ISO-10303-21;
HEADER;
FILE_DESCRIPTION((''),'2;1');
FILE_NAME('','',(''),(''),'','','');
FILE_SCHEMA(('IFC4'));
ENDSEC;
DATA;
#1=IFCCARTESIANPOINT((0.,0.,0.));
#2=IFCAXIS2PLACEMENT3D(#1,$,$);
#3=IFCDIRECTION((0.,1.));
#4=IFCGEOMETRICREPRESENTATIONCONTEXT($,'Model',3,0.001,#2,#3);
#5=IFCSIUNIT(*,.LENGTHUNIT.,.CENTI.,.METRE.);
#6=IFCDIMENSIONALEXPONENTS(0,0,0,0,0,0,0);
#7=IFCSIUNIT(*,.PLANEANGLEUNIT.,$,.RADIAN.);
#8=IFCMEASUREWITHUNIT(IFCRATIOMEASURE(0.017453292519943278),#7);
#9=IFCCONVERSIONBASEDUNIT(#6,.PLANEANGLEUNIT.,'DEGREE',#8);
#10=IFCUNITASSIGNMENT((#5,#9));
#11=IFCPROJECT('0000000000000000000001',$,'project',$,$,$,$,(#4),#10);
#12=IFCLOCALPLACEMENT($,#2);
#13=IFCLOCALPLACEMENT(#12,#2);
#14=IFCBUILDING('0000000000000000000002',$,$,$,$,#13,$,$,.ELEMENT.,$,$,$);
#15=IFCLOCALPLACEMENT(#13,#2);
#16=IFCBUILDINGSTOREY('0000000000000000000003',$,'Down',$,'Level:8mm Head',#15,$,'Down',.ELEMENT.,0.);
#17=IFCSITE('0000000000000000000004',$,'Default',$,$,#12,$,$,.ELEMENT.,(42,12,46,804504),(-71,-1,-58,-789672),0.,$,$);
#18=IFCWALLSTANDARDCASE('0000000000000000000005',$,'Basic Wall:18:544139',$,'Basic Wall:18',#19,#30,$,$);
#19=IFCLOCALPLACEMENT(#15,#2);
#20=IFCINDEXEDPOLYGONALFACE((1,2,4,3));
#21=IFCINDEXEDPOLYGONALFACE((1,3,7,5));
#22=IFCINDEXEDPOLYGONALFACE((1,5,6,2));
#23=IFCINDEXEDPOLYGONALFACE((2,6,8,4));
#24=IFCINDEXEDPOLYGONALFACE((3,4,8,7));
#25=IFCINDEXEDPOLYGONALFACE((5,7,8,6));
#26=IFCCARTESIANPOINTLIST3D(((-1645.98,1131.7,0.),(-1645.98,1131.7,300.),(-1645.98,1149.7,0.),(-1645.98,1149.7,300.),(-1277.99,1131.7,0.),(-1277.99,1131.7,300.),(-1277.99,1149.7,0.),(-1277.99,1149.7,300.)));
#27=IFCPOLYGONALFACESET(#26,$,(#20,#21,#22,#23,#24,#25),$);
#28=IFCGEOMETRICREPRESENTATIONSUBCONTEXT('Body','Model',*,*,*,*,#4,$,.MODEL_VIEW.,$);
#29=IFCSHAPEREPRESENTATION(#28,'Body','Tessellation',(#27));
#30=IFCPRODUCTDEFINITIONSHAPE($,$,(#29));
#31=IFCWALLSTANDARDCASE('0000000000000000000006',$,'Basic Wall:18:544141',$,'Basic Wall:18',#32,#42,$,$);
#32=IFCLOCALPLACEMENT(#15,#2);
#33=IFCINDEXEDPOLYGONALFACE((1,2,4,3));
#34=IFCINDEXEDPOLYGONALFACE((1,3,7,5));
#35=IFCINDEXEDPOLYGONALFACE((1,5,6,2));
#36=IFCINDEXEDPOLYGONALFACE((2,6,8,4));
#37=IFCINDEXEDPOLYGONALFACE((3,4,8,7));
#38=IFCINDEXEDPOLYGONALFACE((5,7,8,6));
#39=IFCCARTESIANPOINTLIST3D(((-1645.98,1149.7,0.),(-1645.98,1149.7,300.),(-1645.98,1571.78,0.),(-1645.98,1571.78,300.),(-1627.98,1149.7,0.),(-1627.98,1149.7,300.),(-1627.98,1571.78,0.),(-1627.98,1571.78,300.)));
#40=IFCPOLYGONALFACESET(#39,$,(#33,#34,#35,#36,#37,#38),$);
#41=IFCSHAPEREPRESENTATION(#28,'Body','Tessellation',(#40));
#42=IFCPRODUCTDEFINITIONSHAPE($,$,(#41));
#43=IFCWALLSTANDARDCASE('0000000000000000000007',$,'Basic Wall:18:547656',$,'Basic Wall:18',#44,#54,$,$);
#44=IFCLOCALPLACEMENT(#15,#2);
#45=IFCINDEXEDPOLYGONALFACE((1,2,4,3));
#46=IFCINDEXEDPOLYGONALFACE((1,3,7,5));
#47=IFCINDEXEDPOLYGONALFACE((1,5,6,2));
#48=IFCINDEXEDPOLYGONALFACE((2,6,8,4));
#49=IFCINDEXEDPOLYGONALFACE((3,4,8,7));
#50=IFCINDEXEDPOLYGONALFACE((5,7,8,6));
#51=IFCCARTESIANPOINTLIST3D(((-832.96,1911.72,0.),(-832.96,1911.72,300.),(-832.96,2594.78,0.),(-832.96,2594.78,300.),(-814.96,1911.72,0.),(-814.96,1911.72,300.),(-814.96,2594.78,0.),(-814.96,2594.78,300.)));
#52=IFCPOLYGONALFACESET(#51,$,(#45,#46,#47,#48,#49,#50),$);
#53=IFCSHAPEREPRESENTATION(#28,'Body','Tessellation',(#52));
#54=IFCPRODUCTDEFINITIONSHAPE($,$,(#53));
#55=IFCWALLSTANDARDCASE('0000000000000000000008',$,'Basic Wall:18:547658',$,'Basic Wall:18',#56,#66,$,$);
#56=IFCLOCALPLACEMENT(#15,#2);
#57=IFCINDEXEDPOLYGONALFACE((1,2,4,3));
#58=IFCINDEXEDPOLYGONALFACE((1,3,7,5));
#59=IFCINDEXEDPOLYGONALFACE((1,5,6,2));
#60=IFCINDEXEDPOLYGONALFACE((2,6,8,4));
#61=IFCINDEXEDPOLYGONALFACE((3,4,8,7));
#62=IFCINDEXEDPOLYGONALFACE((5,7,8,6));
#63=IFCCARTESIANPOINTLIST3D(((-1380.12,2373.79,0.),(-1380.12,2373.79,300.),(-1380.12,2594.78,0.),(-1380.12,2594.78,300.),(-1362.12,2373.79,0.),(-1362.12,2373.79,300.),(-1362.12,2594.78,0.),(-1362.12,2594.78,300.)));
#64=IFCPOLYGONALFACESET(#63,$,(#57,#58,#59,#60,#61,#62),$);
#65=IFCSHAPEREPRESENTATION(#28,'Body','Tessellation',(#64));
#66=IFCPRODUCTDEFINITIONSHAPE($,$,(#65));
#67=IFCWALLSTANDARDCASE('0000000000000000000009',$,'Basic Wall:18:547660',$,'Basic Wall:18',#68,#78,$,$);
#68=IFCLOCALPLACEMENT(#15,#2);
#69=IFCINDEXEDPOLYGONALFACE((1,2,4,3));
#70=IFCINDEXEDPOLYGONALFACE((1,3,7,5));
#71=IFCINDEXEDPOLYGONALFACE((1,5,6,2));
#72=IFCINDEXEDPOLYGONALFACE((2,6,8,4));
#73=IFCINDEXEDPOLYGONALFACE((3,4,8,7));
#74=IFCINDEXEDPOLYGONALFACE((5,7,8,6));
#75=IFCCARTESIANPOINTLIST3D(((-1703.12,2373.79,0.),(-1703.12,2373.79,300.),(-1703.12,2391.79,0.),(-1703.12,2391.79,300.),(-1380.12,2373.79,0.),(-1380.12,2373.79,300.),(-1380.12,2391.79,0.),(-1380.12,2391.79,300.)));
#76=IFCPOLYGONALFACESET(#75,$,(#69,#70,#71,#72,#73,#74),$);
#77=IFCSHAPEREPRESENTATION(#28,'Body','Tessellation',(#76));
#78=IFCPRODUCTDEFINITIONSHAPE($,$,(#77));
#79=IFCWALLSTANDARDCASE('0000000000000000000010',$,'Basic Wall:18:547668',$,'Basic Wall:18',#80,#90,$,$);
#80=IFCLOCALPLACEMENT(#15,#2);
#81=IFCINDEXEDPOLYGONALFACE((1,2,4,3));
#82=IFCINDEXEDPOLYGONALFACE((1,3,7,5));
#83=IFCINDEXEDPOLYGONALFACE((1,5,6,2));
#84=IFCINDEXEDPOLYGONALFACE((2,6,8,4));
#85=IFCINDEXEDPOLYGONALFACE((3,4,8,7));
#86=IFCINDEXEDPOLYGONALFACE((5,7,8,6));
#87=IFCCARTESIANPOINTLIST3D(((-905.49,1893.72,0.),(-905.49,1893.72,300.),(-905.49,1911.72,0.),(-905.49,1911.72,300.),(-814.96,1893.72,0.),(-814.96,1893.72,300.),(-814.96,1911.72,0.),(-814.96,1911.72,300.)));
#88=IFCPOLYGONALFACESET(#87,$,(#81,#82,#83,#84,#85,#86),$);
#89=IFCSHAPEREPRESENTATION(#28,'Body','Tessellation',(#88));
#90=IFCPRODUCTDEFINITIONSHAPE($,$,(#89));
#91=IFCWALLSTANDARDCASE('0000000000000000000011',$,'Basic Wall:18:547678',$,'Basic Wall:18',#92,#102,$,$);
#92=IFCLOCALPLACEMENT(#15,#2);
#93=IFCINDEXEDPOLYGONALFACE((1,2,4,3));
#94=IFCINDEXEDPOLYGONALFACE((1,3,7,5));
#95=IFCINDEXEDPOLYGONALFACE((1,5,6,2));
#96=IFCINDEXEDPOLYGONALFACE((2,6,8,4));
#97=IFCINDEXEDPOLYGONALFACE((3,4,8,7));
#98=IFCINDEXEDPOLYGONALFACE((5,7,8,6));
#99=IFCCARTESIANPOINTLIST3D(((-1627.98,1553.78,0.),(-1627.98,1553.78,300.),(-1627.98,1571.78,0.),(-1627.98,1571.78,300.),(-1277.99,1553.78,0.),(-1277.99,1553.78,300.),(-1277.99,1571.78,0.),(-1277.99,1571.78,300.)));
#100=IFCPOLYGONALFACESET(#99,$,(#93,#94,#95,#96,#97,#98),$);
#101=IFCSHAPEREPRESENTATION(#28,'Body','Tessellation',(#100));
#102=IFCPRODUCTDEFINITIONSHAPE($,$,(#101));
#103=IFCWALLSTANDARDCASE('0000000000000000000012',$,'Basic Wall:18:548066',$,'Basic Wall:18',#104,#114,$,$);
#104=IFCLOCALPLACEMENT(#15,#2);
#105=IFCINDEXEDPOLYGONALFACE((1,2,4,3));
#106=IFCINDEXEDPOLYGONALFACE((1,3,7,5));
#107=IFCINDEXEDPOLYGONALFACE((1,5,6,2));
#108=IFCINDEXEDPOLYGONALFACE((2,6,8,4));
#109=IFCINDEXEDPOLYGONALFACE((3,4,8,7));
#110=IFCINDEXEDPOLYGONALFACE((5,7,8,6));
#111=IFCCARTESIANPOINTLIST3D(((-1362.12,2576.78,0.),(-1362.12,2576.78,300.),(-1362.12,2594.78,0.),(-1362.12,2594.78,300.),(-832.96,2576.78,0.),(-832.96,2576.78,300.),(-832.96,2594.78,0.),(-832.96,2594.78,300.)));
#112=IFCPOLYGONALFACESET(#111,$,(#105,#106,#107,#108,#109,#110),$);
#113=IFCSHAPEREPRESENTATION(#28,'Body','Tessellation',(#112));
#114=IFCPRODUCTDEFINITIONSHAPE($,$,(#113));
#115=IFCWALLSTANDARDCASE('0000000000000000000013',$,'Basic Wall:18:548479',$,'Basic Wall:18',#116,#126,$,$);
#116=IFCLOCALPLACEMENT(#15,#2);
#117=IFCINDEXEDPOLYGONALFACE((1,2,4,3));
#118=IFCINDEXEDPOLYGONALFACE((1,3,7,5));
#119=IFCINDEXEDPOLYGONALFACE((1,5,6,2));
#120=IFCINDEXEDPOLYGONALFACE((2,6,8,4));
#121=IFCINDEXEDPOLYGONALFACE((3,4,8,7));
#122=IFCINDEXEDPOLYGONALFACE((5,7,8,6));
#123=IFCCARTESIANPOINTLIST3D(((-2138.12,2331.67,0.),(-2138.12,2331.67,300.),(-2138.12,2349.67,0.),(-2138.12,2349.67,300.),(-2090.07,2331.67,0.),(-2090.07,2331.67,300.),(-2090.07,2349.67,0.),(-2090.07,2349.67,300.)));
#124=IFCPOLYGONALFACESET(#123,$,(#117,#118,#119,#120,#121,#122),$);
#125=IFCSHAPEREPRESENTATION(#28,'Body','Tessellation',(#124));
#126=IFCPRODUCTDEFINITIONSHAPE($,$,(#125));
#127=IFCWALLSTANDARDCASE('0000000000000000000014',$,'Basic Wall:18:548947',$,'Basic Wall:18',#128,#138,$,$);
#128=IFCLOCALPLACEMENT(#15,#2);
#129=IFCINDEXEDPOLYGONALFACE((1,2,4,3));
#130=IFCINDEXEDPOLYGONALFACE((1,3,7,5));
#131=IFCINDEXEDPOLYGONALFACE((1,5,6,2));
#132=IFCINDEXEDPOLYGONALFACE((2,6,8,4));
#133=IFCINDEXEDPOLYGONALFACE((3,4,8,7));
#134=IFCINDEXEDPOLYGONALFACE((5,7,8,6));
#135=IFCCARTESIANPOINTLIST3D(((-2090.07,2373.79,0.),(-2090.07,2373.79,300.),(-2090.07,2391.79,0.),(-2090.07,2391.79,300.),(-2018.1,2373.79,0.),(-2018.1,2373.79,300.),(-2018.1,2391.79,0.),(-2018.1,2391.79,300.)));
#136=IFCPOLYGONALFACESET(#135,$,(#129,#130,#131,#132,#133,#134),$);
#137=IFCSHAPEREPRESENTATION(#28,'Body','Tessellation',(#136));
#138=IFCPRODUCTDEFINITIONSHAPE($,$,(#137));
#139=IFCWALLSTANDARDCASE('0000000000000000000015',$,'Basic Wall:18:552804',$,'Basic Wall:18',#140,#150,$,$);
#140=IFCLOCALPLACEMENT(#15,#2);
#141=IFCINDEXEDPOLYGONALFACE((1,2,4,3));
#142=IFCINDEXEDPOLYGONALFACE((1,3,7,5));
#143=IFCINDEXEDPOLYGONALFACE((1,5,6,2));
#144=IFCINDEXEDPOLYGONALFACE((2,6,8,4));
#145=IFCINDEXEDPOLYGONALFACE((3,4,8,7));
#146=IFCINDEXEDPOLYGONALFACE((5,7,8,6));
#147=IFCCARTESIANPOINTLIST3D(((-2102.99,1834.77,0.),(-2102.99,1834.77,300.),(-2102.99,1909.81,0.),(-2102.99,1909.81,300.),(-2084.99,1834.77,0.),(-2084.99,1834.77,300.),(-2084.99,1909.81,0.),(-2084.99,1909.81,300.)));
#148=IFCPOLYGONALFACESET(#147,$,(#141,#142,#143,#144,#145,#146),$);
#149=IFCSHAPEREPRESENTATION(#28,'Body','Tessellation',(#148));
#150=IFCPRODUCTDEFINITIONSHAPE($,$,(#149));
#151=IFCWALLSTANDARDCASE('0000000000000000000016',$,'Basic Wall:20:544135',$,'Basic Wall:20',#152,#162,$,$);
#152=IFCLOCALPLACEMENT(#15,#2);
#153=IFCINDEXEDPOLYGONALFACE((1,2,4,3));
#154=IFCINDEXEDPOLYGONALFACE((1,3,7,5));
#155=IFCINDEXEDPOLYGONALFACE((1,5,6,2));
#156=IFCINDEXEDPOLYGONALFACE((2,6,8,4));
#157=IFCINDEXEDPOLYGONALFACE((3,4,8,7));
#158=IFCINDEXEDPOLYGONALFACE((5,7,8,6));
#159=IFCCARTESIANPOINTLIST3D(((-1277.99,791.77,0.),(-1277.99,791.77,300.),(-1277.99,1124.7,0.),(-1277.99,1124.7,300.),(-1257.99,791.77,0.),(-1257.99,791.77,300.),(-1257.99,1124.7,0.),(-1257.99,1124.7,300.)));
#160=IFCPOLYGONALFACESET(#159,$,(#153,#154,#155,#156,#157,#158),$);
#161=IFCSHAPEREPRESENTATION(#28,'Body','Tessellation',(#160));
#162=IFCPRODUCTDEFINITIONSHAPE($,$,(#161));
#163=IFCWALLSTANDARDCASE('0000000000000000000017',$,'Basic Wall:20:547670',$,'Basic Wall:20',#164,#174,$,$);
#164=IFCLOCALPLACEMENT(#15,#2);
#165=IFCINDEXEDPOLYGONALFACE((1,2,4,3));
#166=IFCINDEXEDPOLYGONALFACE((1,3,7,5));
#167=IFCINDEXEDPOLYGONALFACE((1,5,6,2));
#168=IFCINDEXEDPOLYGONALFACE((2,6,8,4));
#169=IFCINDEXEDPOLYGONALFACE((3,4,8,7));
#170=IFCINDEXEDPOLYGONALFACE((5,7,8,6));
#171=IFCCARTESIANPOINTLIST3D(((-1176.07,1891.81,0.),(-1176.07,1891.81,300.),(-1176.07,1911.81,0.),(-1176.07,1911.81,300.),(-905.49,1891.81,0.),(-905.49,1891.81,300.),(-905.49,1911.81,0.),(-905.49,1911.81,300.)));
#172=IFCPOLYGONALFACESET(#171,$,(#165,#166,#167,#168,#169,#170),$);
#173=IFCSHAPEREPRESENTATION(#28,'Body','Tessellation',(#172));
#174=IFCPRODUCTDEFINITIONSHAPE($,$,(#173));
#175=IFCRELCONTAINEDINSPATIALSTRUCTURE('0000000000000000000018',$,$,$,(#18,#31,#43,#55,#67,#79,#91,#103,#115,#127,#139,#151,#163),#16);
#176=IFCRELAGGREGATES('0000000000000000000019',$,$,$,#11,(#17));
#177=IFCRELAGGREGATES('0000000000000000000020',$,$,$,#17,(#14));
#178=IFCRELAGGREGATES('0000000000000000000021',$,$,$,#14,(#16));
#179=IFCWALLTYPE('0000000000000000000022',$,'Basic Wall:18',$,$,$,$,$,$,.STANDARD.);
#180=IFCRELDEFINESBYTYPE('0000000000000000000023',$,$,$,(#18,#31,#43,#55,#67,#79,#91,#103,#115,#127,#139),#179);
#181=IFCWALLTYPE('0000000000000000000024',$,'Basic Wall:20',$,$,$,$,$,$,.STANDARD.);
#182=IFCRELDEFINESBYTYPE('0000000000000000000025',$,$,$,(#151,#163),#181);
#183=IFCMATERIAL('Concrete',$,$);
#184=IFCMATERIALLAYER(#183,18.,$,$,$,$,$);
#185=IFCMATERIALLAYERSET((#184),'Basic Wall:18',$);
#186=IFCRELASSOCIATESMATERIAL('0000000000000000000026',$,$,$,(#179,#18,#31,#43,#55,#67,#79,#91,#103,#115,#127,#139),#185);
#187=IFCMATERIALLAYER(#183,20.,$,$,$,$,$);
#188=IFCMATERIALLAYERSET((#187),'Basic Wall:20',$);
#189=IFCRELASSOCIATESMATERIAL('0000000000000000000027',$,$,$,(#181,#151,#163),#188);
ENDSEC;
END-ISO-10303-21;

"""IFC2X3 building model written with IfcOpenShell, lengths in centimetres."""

from ifc_helpers import new_model, entity, si_unit, converted_unit, direction, frame, frame_2d, origin, place, context, subcontext, project, spatial, rectangle, extrude, material, layer, layer_set, layer_usage, type_object, element, save


model = new_model("IFC2X3")

# Units and contexts
model_context = context("Model", 3, precision=0.001, world=origin(), true_north=direction((0.0, 1.0)))
body_context = subcontext(model_context, "Body", "Model", "MODEL_VIEW")
ifc_project = project(units=[si_unit("LENGTHUNIT", "METRE", prefix="CENTI"), converted_unit("PLANEANGLEUNIT", "DEGREE", entity("IfcRatioMeasure", 0.017453292519943278), si_unit("PLANEANGLEUNIT", "RADIAN"), dimensions=[0, 0, 0, 0, 0, 0, 0])], contexts=[model_context])

# Site, building, storey
site_placement = place(None, origin())
site = spatial("IfcSite", under=ifc_project, at=site_placement, Name="Default", CompositionType="ELEMENT", RefLatitude=(42, 12, 46, 804504), RefLongitude=(-71, -1, -58, -789672), RefElevation=0.0)
building_placement = place(site_placement, origin())
building = spatial("IfcBuilding", under=site, at=building_placement, CompositionType="ELEMENT")
storey_placement = place(building_placement, origin())
storey = spatial("IfcBuildingStorey", under=building, at=storey_placement, Name="Down", ObjectType="Level:8mm Head", LongName="Down", CompositionType="ELEMENT", Elevation=0.0)

# Walls
ifc_material = material(Name="Concrete")
ifc_layer_1 = layer(ifc_material, 18.0)
ifc_layer_set_1 = layer_set([ifc_layer_1], Name="Basic Wall:18")
ifc_layer_usage_1 = layer_usage(ifc_layer_set_1, "AXIS2", "POSITIVE", -9.0)
wall_type_1 = type_object("IfcWallType", Name="Basic Wall:18", PredefinedType="STANDARD", material=ifc_layer_set_1)
wall_1_placement = place(storey_placement, frame((-1277.99, 1140.7, 0.0), z_axis=(0.0, 0.0, 1.0), x_axis=(-1.0, 0.0, 0.0)))
element("IfcWallStandardCase", 1, at=wall_1_placement, inside=storey, type_object=wall_type_1, material=ifc_layer_usage_1, Name="Basic Wall:18:544139", ObjectType="Basic Wall:18", context=body_context, shape_type="SweptSolid", body=[
    extrude(rectangle(XDim=367.99, YDim=18.0, at=frame_2d((184.0, 0.0), x_axis=(-1.0, 0.0))), origin(), (0.0, 0.0, 1.0), 300.0),
])
ifc_layer_usage_2 = layer_usage(ifc_layer_set_1, "AXIS2", "NEGATIVE", 9.0)
wall_2_placement = place(storey_placement, frame((-1636.98, 1149.7, 0.0), z_axis=(0.0, 0.0, 1.0), x_axis=(0.0, 1.0, 0.0)))
element("IfcWallStandardCase", 2, at=wall_2_placement, inside=storey, type_object=wall_type_1, material=ifc_layer_usage_2, Name="Basic Wall:18:544141", ObjectType="Basic Wall:18", context=body_context, shape_type="SweptSolid", body=[
    extrude(rectangle(XDim=422.07, YDim=18.0, at=frame_2d((211.04, 0.0), x_axis=(-1.0, 0.0))), origin(), (0.0, 0.0, 1.0), 300.0),
])
ifc_layer_usage_3 = layer_usage(ifc_layer_set_1, "AXIS2", "POSITIVE", -9.0)
wall_3_placement = place(storey_placement, frame((-823.96, 1911.72, 0.0), z_axis=(0.0, 0.0, 1.0), x_axis=(0.0, 1.0, 0.0)))
element("IfcWallStandardCase", 3, at=wall_3_placement, inside=storey, type_object=wall_type_1, material=ifc_layer_usage_3, Name="Basic Wall:18:547656", ObjectType="Basic Wall:18", context=body_context, shape_type="SweptSolid", body=[
    extrude(rectangle(XDim=683.06, YDim=18.0, at=frame_2d((341.53, 0.0), x_axis=(-1.0, 0.0))), origin(), (0.0, 0.0, 1.0), 300.0),
])
ifc_layer_usage_4 = layer_usage(ifc_layer_set_1, "AXIS2", "POSITIVE", -9.0)
wall_4_placement = place(storey_placement, frame((-1371.12, 2594.78, 0.0), z_axis=(0.0, 0.0, 1.0), x_axis=(0.0, -1.0, 0.0)))
element("IfcWallStandardCase", 4, at=wall_4_placement, inside=storey, type_object=wall_type_1, material=ifc_layer_usage_4, Name="Basic Wall:18:547658", ObjectType="Basic Wall:18", context=body_context, shape_type="SweptSolid", body=[
    extrude(rectangle(XDim=220.99, YDim=18.0, at=frame_2d((110.5, 0.0), x_axis=(-1.0, 0.0))), origin(), (0.0, 0.0, 1.0), 300.0),
])
ifc_layer_usage_5 = layer_usage(ifc_layer_set_1, "AXIS2", "NEGATIVE", 9.0)
wall_5_placement = place(storey_placement, frame((-1380.12, 2382.79, 0.0), z_axis=(0.0, 0.0, 1.0), x_axis=(-1.0, 0.0, 0.0)))
element("IfcWallStandardCase", 5, at=wall_5_placement, inside=storey, type_object=wall_type_1, material=ifc_layer_usage_5, Name="Basic Wall:18:547660", ObjectType="Basic Wall:18", context=body_context, shape_type="SweptSolid", body=[
    extrude(rectangle(XDim=323.0, YDim=18.0, at=frame_2d((161.5, 0.0), x_axis=(-1.0, 0.0))), origin(), (0.0, 0.0, 1.0), 300.0),
])
ifc_layer_usage_6 = layer_usage(ifc_layer_set_1, "AXIS2", "NEGATIVE", 9.0)
wall_6_placement = place(storey_placement, frame((-814.96, 1902.72, 0.0), z_axis=(0.0, 0.0, 1.0), x_axis=(-1.0, 0.0, 0.0)))
element("IfcWallStandardCase", 6, at=wall_6_placement, inside=storey, type_object=wall_type_1, material=ifc_layer_usage_6, Name="Basic Wall:18:547668", ObjectType="Basic Wall:18", context=body_context, shape_type="SweptSolid", body=[
    extrude(rectangle(XDim=90.53, YDim=18.0, at=frame_2d((45.26, 0.0), x_axis=(-1.0, 0.0))), origin(), (0.0, 0.0, 1.0), 300.0),
])
ifc_layer_usage_7 = layer_usage(ifc_layer_set_1, "AXIS2", "NEGATIVE", 9.0)
wall_7_placement = place(storey_placement, frame((-1277.99, 1562.78, 0.0), z_axis=(0.0, 0.0, 1.0), x_axis=(-1.0, 0.0, 0.0)))
element("IfcWallStandardCase", 7, at=wall_7_placement, inside=storey, type_object=wall_type_1, material=ifc_layer_usage_7, Name="Basic Wall:18:547678", ObjectType="Basic Wall:18", context=body_context, shape_type="SweptSolid", body=[
    extrude(rectangle(XDim=349.99, YDim=18.0, at=frame_2d((175.0, 0.0), x_axis=(-1.0, 0.0))), origin(), (0.0, 0.0, 1.0), 300.0),
])
ifc_layer_usage_8 = layer_usage(ifc_layer_set_1, "AXIS2", "POSITIVE", -9.0)
wall_8_placement = place(storey_placement, frame((-832.96, 2585.78, 0.0), z_axis=(0.0, 0.0, 1.0), x_axis=(-1.0, 0.0, 0.0)))
element("IfcWallStandardCase", 8, at=wall_8_placement, inside=storey, type_object=wall_type_1, material=ifc_layer_usage_8, Name="Basic Wall:18:548066", ObjectType="Basic Wall:18", context=body_context, shape_type="SweptSolid", body=[
    extrude(rectangle(XDim=529.16, YDim=18.0, at=frame_2d((264.58, 0.0), x_axis=(-1.0, 0.0))), origin(), (0.0, 0.0, 1.0), 300.0),
])
ifc_layer_usage_9 = layer_usage(ifc_layer_set_1, "AXIS2", "POSITIVE", -9.0)
wall_9_placement = place(storey_placement, frame((-2138.12, 2340.67, 0.0)))
element("IfcWallStandardCase", 9, at=wall_9_placement, inside=storey, type_object=wall_type_1, material=ifc_layer_usage_9, Name="Basic Wall:18:548479", ObjectType="Basic Wall:18", context=body_context, shape_type="SweptSolid", body=[
    extrude(rectangle(XDim=48.05, YDim=18.0, at=frame_2d((24.02, 0.0), x_axis=(-1.0, 0.0))), origin(), (0.0, 0.0, 1.0), 300.0),
])
ifc_layer_usage_10 = layer_usage(ifc_layer_set_1, "AXIS2", "NEGATIVE", 9.0)
wall_10_placement = place(storey_placement, frame((-2090.07, 2382.79, 0.0)))
element("IfcWallStandardCase", 10, at=wall_10_placement, inside=storey, type_object=wall_type_1, material=ifc_layer_usage_10, Name="Basic Wall:18:548947", ObjectType="Basic Wall:18", context=body_context, shape_type="SweptSolid", body=[
    extrude(rectangle(XDim=71.97, YDim=18.0, at=frame_2d((35.98, 0.0), x_axis=(-1.0, 0.0))), origin(), (0.0, 0.0, 1.0), 300.0),
])
ifc_layer_usage_11 = layer_usage(ifc_layer_set_1, "AXIS2", "POSITIVE", -9.0)
wall_11_placement = place(storey_placement, frame((-2093.99, 1834.77, 0.0), z_axis=(0.0, 0.0, 1.0), x_axis=(0.0, 1.0, 0.0)))
element("IfcWallStandardCase", 11, at=wall_11_placement, inside=storey, type_object=wall_type_1, material=ifc_layer_usage_11, Name="Basic Wall:18:552804", ObjectType="Basic Wall:18", context=body_context, shape_type="SweptSolid", body=[
    extrude(rectangle(XDim=75.04, YDim=18.0, at=frame_2d((37.52, 0.0), x_axis=(-1.0, 0.0))), origin(), (0.0, 0.0, 1.0), 300.0),
])
ifc_layer_2 = layer(ifc_material, 20.0)
ifc_layer_set_2 = layer_set([ifc_layer_2], Name="Basic Wall:20")
ifc_layer_usage_12 = layer_usage(ifc_layer_set_2, "AXIS2", "NEGATIVE", 10.0)
wall_type_2 = type_object("IfcWallType", Name="Basic Wall:20", PredefinedType="STANDARD", material=ifc_layer_set_2)
wall_12_placement = place(storey_placement, frame((-1267.99, 1124.7, 0.0), z_axis=(0.0, 0.0, 1.0), x_axis=(0.0, -1.0, 0.0)))
element("IfcWallStandardCase", 12, at=wall_12_placement, inside=storey, type_object=wall_type_2, material=ifc_layer_usage_12, Name="Basic Wall:20:544135", ObjectType="Basic Wall:20", context=body_context, shape_type="SweptSolid", body=[
    extrude(rectangle(XDim=332.94, YDim=20.0, at=frame_2d((166.47, 0.0), x_axis=(-1.0, 0.0))), origin(), (0.0, 0.0, 1.0), 300.0),
])
ifc_layer_usage_13 = layer_usage(ifc_layer_set_2, "AXIS2", "POSITIVE", -10.0)
wall_13_placement = place(storey_placement, frame((-1176.07, 1901.81, 0.0)))
element("IfcWallStandardCase", 13, at=wall_13_placement, inside=storey, type_object=wall_type_2, material=ifc_layer_usage_13, Name="Basic Wall:20:547670", ObjectType="Basic Wall:20", context=body_context, shape_type="SweptSolid", body=[
    extrude(rectangle(XDim=270.58, YDim=20.0, at=frame_2d((135.29, 0.0), x_axis=(-1.0, 0.0))), origin(), (0.0, 0.0, 1.0), 300.0),
])

save(model, "model.ifc")
